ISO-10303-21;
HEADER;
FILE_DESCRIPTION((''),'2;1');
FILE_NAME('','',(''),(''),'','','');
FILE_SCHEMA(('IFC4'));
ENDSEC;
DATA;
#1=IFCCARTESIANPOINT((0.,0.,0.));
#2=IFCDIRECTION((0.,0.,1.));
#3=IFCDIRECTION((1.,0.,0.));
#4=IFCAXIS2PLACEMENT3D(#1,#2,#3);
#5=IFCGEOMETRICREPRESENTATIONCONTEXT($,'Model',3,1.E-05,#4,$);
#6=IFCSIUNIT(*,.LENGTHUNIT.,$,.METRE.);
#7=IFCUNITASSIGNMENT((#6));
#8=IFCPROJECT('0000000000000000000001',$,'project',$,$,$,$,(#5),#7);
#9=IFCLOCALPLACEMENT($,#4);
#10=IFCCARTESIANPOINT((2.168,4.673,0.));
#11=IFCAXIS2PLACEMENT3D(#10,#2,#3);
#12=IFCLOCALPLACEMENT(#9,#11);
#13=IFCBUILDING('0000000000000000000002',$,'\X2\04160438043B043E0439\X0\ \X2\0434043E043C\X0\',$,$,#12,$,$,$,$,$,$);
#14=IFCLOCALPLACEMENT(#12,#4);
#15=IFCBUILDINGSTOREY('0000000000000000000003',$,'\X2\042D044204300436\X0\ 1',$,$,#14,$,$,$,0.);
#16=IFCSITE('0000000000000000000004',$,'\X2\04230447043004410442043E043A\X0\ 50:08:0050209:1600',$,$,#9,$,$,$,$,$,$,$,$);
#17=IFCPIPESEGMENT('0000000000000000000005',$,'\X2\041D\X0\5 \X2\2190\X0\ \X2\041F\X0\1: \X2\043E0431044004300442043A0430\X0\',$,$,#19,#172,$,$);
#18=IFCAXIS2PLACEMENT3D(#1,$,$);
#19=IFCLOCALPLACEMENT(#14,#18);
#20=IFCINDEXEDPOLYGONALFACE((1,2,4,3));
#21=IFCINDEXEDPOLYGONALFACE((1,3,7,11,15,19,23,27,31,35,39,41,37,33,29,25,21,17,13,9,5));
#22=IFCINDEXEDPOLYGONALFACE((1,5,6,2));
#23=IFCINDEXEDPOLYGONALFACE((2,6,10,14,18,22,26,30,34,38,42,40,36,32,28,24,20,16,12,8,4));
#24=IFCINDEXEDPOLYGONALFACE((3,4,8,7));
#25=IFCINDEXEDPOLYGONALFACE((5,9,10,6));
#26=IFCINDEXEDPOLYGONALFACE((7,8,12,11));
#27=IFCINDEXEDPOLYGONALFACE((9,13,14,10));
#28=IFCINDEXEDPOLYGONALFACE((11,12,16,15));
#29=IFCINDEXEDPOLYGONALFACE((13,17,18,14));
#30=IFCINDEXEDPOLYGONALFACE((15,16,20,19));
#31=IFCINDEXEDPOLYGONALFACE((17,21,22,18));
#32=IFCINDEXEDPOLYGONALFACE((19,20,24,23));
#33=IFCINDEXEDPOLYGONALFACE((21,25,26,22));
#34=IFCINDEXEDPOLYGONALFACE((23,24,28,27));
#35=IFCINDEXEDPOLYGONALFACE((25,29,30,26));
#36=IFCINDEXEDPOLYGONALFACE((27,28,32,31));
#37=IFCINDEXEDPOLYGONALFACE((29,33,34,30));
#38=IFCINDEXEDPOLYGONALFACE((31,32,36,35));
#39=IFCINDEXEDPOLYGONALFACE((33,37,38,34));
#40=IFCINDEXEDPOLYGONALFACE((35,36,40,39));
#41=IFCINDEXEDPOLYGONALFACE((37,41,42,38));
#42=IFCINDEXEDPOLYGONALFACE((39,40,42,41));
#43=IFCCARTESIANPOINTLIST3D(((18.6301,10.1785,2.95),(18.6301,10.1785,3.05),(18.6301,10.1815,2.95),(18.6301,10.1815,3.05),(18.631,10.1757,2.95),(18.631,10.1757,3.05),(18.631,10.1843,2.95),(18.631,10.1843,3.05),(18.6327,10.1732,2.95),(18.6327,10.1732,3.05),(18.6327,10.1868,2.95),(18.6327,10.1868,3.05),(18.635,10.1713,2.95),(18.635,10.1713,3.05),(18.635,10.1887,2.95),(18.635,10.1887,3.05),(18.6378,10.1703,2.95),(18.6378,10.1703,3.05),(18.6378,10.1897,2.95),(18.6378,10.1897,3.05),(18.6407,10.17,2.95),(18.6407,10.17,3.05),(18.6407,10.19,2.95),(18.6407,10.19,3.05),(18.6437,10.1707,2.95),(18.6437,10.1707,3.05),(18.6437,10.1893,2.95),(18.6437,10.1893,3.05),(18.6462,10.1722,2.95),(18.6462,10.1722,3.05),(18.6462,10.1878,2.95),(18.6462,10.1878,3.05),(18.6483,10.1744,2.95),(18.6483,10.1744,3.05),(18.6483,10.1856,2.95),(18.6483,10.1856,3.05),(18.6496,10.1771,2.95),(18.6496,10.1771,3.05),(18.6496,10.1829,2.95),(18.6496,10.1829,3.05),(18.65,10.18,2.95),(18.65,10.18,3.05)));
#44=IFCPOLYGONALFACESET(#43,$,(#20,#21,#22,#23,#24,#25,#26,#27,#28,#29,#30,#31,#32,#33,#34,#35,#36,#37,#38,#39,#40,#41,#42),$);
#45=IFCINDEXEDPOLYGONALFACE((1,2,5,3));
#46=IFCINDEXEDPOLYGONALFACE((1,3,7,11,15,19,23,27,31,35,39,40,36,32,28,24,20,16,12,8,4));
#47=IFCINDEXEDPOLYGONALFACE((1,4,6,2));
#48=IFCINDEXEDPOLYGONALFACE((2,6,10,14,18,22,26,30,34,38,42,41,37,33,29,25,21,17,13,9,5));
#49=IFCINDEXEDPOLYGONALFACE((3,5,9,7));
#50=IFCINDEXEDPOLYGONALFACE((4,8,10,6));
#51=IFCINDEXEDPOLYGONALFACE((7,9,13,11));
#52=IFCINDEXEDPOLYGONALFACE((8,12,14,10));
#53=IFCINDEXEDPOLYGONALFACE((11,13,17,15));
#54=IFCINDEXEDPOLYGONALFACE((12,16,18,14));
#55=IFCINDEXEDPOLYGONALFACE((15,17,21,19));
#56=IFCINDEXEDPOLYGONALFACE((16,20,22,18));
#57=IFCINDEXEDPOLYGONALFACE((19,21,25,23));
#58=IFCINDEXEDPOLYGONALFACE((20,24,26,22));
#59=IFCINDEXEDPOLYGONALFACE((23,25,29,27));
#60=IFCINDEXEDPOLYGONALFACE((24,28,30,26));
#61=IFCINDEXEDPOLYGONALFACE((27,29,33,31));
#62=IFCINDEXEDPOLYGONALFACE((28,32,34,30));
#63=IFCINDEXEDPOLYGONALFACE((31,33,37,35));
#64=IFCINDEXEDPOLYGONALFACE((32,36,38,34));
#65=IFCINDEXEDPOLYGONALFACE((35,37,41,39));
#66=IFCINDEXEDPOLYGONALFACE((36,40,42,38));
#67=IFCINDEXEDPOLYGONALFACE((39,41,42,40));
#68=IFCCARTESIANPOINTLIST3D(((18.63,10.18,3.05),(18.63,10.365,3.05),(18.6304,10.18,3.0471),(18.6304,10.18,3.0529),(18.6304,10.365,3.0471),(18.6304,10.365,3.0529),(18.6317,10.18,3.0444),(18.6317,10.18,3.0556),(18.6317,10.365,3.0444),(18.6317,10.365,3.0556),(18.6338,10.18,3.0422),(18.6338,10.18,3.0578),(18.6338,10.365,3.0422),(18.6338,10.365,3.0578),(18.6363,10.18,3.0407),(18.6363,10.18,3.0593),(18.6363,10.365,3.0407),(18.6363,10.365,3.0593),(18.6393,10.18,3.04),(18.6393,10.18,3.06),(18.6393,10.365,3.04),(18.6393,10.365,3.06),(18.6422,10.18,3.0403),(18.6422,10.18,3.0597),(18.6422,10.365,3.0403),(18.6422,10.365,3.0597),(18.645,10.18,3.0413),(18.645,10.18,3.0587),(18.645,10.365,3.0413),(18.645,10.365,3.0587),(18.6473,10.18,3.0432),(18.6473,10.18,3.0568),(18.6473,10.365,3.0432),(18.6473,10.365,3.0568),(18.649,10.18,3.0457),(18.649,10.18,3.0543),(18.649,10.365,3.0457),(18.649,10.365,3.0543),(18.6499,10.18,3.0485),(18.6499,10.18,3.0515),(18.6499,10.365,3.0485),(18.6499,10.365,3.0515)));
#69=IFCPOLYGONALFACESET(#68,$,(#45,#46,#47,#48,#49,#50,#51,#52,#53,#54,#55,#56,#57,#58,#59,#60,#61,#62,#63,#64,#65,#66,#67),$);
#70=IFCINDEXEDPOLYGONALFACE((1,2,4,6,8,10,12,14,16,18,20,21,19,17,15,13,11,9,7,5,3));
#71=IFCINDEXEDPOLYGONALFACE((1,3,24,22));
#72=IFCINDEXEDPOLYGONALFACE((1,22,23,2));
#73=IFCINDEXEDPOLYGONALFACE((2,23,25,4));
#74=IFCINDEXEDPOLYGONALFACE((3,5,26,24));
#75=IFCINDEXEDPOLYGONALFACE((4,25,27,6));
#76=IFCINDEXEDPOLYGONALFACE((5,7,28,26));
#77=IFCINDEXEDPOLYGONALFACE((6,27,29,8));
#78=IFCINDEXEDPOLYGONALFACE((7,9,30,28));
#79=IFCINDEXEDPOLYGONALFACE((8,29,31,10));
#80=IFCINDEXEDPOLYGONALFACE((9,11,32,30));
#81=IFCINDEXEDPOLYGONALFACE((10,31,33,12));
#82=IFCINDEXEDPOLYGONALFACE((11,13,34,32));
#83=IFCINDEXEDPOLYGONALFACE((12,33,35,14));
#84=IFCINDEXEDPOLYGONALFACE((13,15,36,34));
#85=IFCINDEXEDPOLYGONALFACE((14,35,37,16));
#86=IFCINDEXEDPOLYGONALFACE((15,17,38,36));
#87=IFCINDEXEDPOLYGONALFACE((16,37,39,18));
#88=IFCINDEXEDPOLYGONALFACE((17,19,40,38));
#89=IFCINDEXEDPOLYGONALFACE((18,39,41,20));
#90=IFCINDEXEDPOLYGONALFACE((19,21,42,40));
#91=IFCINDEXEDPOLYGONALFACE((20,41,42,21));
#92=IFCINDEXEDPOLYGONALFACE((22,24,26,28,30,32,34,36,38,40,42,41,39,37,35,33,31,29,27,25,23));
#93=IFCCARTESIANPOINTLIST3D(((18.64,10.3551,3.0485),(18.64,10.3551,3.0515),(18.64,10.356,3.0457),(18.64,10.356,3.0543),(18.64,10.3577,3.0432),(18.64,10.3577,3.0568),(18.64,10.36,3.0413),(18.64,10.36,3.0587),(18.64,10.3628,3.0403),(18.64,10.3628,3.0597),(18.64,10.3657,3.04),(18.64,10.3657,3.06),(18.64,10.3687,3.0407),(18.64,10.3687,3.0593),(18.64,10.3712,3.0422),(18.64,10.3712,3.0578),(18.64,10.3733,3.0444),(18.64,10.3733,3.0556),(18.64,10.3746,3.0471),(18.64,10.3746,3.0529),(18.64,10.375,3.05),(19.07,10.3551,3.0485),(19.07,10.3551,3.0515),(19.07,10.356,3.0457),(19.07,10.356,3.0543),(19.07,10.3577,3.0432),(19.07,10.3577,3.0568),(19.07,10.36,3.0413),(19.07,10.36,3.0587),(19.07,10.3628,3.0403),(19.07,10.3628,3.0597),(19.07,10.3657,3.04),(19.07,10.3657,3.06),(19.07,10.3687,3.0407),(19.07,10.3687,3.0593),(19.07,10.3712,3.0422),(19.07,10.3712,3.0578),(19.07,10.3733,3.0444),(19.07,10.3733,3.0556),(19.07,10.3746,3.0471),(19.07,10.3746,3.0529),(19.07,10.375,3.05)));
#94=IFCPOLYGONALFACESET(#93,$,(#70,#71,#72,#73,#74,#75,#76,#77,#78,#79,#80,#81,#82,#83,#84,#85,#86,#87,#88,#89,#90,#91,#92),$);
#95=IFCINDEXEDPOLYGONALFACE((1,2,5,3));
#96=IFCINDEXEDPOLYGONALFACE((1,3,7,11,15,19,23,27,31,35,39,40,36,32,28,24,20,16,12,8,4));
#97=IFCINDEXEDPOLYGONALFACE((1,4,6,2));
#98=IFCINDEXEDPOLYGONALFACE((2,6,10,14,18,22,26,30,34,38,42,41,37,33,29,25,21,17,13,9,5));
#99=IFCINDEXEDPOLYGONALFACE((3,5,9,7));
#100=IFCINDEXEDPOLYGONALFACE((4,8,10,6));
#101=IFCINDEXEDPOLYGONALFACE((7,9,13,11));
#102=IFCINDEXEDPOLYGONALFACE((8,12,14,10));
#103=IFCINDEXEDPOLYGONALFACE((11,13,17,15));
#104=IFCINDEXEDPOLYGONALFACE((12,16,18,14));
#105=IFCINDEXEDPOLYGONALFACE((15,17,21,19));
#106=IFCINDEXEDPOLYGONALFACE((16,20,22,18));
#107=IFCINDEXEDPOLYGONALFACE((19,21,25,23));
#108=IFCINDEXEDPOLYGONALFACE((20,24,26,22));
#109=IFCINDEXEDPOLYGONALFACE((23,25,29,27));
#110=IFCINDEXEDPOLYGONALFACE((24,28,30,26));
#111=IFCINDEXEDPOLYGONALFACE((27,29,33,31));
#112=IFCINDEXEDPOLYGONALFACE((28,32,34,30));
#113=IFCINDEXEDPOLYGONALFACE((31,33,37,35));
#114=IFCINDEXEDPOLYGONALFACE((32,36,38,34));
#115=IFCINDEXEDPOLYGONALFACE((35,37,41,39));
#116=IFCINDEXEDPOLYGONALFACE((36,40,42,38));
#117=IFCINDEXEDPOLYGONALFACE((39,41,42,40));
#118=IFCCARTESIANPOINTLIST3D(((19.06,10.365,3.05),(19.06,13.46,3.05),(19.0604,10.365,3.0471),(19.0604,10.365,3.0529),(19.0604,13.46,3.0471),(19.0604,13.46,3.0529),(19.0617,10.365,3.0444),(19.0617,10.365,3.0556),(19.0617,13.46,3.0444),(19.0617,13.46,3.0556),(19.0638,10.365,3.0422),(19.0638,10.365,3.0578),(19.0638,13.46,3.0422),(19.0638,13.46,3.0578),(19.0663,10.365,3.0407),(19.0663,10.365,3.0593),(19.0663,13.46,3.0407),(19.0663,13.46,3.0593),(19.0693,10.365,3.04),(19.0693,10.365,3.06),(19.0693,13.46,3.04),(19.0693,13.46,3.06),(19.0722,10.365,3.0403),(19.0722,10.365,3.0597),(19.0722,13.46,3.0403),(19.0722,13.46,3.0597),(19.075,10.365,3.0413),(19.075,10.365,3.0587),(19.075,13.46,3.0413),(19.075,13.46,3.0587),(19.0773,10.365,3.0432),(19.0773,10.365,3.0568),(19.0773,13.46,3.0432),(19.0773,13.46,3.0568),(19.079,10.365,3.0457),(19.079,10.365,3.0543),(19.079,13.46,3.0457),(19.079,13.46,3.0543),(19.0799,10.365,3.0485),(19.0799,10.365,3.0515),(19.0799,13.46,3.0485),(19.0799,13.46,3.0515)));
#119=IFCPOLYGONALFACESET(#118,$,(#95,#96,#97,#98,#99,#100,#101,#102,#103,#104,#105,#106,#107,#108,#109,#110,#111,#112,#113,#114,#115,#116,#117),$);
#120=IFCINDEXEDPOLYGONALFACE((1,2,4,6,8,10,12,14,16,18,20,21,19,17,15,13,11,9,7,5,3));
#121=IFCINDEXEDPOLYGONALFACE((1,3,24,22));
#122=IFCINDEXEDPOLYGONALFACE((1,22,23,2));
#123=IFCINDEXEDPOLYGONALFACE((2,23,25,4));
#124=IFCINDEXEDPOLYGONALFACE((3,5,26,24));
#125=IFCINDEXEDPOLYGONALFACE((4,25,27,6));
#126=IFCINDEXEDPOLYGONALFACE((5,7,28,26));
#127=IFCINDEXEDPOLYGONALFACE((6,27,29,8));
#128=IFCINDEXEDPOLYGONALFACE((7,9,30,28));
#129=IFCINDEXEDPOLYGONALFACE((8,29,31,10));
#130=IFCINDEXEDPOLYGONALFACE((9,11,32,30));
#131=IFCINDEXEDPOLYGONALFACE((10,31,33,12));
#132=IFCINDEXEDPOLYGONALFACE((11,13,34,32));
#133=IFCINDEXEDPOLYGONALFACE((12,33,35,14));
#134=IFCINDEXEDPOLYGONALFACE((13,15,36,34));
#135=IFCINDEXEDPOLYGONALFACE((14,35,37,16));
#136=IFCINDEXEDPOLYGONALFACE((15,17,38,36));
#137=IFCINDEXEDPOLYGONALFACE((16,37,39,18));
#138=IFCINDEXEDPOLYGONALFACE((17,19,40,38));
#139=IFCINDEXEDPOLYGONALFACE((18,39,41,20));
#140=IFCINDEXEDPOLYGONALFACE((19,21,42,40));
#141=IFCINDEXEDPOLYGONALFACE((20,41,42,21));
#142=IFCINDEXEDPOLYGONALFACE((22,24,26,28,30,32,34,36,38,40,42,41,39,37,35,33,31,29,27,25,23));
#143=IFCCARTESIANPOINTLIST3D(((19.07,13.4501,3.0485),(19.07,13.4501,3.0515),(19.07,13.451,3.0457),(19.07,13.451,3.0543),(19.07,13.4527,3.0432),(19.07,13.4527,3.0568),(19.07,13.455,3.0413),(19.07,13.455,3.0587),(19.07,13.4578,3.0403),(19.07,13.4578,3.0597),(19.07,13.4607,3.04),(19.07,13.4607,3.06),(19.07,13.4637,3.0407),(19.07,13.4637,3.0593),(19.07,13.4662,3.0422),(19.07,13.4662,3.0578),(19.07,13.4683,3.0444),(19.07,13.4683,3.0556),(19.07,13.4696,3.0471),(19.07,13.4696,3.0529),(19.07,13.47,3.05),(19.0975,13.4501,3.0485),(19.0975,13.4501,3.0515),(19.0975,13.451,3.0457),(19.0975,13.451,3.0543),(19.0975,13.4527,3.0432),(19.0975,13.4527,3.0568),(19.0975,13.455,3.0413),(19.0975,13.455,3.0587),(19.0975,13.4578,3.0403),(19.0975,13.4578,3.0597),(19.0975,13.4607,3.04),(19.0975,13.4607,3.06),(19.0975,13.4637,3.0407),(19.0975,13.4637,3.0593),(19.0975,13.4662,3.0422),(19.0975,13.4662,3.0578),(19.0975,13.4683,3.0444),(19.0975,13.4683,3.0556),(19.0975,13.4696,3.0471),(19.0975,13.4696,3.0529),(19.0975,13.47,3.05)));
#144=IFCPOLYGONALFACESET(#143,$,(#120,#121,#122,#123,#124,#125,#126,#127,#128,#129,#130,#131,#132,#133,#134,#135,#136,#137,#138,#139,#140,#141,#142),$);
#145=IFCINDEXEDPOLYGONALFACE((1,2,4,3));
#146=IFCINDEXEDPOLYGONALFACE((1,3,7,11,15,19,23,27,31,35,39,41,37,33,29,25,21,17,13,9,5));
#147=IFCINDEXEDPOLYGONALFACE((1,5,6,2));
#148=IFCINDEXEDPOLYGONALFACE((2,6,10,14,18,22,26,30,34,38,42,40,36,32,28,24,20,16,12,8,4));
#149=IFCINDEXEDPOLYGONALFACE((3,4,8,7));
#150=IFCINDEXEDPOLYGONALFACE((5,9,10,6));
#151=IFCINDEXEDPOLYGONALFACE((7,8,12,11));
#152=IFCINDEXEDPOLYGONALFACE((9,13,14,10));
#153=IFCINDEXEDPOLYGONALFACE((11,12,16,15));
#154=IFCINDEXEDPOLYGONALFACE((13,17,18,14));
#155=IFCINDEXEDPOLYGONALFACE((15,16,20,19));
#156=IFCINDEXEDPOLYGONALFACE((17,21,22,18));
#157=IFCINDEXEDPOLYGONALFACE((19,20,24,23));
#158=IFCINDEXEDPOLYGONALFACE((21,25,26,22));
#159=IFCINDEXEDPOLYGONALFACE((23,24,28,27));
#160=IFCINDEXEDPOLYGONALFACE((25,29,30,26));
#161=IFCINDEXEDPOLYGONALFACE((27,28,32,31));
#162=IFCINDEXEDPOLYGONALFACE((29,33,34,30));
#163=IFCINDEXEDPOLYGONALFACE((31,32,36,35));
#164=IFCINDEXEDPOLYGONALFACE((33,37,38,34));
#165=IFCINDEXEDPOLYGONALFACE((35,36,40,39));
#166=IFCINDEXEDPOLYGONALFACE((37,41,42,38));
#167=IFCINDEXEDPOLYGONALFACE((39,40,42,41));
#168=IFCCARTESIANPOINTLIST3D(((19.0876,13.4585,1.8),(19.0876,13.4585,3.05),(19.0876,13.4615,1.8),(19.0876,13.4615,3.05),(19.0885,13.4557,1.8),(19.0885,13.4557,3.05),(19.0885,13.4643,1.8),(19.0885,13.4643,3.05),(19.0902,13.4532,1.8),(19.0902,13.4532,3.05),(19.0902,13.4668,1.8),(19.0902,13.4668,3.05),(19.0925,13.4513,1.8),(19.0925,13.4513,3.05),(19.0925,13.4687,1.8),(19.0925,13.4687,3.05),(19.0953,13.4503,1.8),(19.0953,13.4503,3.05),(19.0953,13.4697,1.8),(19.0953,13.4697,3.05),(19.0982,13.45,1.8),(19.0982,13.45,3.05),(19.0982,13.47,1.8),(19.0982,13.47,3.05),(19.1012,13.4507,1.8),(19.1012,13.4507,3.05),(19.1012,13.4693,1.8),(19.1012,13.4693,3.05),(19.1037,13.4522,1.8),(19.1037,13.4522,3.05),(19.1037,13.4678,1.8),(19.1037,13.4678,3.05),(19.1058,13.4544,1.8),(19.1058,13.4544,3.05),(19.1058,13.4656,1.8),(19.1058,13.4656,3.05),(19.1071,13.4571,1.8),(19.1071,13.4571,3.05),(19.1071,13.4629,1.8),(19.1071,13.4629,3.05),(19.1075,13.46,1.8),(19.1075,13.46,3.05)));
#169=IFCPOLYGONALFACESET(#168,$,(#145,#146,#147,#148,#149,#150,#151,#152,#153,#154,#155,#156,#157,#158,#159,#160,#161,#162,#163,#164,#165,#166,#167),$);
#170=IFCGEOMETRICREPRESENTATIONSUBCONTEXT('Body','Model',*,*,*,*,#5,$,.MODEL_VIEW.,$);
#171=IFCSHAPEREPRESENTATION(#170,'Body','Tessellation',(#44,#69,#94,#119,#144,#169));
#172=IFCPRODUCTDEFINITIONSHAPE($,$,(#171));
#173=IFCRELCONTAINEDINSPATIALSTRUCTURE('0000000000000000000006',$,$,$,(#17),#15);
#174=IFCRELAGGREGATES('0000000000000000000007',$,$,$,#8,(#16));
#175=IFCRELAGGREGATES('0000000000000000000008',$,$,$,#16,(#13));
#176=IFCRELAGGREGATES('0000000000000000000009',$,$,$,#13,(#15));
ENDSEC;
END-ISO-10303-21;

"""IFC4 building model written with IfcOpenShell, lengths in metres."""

from ifc_helpers import new_model, si_unit, frame, origin_with_axes, origin_2d, place, context, subcontext, project, spatial, circle, extrude, element, save


model = new_model("IFC4")

# Units and contexts
model_context = context("Model", 3, precision=1e-05, world=origin_with_axes())
body_context = subcontext(model_context, "Body", "Model", "MODEL_VIEW")
ifc_project = project(units=[si_unit("LENGTHUNIT", "METRE")], contexts=[model_context])

# Site, building, storey
site_placement = place(None, origin_with_axes())
site = spatial("IfcSite", under=ifc_project, at=site_placement, Name="Участок 50:08:0050209:1600")
building_placement = place(site_placement, frame((2.168, 4.673, 0.0), z_axis=(0.0, 0.0, 1.0), x_axis=(1.0, 0.0, 0.0)))
building = spatial("IfcBuilding", under=site, at=building_placement, Name="Жилой дом")
storey_placement = place(building_placement, origin_with_axes())
storey = spatial("IfcBuildingStorey", under=building, at=storey_placement, Name="Этаж 1", Elevation=0.0)

# Pipe segment
pipe_segment_1_placement = place(storey_placement, origin_with_axes())
element("IfcPipeSegment", 1, at=pipe_segment_1_placement, inside=storey, Name="Н5 ← П1: обратка", context=body_context, shape_type="SweptSolid", body=[
    extrude(circle(Radius=0.01, at=origin_2d()), frame((18.64, 10.18, 2.95), z_axis=(0.0, 0.0, 1.0), x_axis=(1.0, 0.0, 0.0)), (0.0, 0.0, 1.0), 0.1),
    extrude(circle(Radius=0.01, at=origin_2d()), frame((18.64, 10.18, 3.05), z_axis=(0.0, 1.0, 0.0), x_axis=(-1.0, 0.0, 0.0)), (0.0, 0.0, 1.0), 0.185),
    extrude(circle(Radius=0.01, at=origin_2d()), frame((18.64, 10.365, 3.05), z_axis=(1.0, 0.0, 0.0), x_axis=(0.0, 1.0, 0.0)), (0.0, 0.0, 1.0), 0.43),
    extrude(circle(Radius=0.01, at=origin_2d()), frame((19.07, 10.365, 3.05), z_axis=(0.0, 1.0, 0.0), x_axis=(-1.0, 0.0, 0.0)), (0.0, 0.0, 1.0), 3.095),
    extrude(circle(Radius=0.01, at=origin_2d()), frame((19.07, 13.46, 3.05), z_axis=(1.0, 0.0, 0.0), x_axis=(0.0, 1.0, 0.0)), (0.0, 0.0, 1.0), 0.0275),
    extrude(circle(Radius=0.01, at=origin_2d()), frame((19.0975, 13.46, 3.05), z_axis=(0.0, 0.0, -1.0), x_axis=(1.0, 0.0, 0.0)), (0.0, 0.0, 1.0), 1.25),
])

save(model, "model.ifc")
